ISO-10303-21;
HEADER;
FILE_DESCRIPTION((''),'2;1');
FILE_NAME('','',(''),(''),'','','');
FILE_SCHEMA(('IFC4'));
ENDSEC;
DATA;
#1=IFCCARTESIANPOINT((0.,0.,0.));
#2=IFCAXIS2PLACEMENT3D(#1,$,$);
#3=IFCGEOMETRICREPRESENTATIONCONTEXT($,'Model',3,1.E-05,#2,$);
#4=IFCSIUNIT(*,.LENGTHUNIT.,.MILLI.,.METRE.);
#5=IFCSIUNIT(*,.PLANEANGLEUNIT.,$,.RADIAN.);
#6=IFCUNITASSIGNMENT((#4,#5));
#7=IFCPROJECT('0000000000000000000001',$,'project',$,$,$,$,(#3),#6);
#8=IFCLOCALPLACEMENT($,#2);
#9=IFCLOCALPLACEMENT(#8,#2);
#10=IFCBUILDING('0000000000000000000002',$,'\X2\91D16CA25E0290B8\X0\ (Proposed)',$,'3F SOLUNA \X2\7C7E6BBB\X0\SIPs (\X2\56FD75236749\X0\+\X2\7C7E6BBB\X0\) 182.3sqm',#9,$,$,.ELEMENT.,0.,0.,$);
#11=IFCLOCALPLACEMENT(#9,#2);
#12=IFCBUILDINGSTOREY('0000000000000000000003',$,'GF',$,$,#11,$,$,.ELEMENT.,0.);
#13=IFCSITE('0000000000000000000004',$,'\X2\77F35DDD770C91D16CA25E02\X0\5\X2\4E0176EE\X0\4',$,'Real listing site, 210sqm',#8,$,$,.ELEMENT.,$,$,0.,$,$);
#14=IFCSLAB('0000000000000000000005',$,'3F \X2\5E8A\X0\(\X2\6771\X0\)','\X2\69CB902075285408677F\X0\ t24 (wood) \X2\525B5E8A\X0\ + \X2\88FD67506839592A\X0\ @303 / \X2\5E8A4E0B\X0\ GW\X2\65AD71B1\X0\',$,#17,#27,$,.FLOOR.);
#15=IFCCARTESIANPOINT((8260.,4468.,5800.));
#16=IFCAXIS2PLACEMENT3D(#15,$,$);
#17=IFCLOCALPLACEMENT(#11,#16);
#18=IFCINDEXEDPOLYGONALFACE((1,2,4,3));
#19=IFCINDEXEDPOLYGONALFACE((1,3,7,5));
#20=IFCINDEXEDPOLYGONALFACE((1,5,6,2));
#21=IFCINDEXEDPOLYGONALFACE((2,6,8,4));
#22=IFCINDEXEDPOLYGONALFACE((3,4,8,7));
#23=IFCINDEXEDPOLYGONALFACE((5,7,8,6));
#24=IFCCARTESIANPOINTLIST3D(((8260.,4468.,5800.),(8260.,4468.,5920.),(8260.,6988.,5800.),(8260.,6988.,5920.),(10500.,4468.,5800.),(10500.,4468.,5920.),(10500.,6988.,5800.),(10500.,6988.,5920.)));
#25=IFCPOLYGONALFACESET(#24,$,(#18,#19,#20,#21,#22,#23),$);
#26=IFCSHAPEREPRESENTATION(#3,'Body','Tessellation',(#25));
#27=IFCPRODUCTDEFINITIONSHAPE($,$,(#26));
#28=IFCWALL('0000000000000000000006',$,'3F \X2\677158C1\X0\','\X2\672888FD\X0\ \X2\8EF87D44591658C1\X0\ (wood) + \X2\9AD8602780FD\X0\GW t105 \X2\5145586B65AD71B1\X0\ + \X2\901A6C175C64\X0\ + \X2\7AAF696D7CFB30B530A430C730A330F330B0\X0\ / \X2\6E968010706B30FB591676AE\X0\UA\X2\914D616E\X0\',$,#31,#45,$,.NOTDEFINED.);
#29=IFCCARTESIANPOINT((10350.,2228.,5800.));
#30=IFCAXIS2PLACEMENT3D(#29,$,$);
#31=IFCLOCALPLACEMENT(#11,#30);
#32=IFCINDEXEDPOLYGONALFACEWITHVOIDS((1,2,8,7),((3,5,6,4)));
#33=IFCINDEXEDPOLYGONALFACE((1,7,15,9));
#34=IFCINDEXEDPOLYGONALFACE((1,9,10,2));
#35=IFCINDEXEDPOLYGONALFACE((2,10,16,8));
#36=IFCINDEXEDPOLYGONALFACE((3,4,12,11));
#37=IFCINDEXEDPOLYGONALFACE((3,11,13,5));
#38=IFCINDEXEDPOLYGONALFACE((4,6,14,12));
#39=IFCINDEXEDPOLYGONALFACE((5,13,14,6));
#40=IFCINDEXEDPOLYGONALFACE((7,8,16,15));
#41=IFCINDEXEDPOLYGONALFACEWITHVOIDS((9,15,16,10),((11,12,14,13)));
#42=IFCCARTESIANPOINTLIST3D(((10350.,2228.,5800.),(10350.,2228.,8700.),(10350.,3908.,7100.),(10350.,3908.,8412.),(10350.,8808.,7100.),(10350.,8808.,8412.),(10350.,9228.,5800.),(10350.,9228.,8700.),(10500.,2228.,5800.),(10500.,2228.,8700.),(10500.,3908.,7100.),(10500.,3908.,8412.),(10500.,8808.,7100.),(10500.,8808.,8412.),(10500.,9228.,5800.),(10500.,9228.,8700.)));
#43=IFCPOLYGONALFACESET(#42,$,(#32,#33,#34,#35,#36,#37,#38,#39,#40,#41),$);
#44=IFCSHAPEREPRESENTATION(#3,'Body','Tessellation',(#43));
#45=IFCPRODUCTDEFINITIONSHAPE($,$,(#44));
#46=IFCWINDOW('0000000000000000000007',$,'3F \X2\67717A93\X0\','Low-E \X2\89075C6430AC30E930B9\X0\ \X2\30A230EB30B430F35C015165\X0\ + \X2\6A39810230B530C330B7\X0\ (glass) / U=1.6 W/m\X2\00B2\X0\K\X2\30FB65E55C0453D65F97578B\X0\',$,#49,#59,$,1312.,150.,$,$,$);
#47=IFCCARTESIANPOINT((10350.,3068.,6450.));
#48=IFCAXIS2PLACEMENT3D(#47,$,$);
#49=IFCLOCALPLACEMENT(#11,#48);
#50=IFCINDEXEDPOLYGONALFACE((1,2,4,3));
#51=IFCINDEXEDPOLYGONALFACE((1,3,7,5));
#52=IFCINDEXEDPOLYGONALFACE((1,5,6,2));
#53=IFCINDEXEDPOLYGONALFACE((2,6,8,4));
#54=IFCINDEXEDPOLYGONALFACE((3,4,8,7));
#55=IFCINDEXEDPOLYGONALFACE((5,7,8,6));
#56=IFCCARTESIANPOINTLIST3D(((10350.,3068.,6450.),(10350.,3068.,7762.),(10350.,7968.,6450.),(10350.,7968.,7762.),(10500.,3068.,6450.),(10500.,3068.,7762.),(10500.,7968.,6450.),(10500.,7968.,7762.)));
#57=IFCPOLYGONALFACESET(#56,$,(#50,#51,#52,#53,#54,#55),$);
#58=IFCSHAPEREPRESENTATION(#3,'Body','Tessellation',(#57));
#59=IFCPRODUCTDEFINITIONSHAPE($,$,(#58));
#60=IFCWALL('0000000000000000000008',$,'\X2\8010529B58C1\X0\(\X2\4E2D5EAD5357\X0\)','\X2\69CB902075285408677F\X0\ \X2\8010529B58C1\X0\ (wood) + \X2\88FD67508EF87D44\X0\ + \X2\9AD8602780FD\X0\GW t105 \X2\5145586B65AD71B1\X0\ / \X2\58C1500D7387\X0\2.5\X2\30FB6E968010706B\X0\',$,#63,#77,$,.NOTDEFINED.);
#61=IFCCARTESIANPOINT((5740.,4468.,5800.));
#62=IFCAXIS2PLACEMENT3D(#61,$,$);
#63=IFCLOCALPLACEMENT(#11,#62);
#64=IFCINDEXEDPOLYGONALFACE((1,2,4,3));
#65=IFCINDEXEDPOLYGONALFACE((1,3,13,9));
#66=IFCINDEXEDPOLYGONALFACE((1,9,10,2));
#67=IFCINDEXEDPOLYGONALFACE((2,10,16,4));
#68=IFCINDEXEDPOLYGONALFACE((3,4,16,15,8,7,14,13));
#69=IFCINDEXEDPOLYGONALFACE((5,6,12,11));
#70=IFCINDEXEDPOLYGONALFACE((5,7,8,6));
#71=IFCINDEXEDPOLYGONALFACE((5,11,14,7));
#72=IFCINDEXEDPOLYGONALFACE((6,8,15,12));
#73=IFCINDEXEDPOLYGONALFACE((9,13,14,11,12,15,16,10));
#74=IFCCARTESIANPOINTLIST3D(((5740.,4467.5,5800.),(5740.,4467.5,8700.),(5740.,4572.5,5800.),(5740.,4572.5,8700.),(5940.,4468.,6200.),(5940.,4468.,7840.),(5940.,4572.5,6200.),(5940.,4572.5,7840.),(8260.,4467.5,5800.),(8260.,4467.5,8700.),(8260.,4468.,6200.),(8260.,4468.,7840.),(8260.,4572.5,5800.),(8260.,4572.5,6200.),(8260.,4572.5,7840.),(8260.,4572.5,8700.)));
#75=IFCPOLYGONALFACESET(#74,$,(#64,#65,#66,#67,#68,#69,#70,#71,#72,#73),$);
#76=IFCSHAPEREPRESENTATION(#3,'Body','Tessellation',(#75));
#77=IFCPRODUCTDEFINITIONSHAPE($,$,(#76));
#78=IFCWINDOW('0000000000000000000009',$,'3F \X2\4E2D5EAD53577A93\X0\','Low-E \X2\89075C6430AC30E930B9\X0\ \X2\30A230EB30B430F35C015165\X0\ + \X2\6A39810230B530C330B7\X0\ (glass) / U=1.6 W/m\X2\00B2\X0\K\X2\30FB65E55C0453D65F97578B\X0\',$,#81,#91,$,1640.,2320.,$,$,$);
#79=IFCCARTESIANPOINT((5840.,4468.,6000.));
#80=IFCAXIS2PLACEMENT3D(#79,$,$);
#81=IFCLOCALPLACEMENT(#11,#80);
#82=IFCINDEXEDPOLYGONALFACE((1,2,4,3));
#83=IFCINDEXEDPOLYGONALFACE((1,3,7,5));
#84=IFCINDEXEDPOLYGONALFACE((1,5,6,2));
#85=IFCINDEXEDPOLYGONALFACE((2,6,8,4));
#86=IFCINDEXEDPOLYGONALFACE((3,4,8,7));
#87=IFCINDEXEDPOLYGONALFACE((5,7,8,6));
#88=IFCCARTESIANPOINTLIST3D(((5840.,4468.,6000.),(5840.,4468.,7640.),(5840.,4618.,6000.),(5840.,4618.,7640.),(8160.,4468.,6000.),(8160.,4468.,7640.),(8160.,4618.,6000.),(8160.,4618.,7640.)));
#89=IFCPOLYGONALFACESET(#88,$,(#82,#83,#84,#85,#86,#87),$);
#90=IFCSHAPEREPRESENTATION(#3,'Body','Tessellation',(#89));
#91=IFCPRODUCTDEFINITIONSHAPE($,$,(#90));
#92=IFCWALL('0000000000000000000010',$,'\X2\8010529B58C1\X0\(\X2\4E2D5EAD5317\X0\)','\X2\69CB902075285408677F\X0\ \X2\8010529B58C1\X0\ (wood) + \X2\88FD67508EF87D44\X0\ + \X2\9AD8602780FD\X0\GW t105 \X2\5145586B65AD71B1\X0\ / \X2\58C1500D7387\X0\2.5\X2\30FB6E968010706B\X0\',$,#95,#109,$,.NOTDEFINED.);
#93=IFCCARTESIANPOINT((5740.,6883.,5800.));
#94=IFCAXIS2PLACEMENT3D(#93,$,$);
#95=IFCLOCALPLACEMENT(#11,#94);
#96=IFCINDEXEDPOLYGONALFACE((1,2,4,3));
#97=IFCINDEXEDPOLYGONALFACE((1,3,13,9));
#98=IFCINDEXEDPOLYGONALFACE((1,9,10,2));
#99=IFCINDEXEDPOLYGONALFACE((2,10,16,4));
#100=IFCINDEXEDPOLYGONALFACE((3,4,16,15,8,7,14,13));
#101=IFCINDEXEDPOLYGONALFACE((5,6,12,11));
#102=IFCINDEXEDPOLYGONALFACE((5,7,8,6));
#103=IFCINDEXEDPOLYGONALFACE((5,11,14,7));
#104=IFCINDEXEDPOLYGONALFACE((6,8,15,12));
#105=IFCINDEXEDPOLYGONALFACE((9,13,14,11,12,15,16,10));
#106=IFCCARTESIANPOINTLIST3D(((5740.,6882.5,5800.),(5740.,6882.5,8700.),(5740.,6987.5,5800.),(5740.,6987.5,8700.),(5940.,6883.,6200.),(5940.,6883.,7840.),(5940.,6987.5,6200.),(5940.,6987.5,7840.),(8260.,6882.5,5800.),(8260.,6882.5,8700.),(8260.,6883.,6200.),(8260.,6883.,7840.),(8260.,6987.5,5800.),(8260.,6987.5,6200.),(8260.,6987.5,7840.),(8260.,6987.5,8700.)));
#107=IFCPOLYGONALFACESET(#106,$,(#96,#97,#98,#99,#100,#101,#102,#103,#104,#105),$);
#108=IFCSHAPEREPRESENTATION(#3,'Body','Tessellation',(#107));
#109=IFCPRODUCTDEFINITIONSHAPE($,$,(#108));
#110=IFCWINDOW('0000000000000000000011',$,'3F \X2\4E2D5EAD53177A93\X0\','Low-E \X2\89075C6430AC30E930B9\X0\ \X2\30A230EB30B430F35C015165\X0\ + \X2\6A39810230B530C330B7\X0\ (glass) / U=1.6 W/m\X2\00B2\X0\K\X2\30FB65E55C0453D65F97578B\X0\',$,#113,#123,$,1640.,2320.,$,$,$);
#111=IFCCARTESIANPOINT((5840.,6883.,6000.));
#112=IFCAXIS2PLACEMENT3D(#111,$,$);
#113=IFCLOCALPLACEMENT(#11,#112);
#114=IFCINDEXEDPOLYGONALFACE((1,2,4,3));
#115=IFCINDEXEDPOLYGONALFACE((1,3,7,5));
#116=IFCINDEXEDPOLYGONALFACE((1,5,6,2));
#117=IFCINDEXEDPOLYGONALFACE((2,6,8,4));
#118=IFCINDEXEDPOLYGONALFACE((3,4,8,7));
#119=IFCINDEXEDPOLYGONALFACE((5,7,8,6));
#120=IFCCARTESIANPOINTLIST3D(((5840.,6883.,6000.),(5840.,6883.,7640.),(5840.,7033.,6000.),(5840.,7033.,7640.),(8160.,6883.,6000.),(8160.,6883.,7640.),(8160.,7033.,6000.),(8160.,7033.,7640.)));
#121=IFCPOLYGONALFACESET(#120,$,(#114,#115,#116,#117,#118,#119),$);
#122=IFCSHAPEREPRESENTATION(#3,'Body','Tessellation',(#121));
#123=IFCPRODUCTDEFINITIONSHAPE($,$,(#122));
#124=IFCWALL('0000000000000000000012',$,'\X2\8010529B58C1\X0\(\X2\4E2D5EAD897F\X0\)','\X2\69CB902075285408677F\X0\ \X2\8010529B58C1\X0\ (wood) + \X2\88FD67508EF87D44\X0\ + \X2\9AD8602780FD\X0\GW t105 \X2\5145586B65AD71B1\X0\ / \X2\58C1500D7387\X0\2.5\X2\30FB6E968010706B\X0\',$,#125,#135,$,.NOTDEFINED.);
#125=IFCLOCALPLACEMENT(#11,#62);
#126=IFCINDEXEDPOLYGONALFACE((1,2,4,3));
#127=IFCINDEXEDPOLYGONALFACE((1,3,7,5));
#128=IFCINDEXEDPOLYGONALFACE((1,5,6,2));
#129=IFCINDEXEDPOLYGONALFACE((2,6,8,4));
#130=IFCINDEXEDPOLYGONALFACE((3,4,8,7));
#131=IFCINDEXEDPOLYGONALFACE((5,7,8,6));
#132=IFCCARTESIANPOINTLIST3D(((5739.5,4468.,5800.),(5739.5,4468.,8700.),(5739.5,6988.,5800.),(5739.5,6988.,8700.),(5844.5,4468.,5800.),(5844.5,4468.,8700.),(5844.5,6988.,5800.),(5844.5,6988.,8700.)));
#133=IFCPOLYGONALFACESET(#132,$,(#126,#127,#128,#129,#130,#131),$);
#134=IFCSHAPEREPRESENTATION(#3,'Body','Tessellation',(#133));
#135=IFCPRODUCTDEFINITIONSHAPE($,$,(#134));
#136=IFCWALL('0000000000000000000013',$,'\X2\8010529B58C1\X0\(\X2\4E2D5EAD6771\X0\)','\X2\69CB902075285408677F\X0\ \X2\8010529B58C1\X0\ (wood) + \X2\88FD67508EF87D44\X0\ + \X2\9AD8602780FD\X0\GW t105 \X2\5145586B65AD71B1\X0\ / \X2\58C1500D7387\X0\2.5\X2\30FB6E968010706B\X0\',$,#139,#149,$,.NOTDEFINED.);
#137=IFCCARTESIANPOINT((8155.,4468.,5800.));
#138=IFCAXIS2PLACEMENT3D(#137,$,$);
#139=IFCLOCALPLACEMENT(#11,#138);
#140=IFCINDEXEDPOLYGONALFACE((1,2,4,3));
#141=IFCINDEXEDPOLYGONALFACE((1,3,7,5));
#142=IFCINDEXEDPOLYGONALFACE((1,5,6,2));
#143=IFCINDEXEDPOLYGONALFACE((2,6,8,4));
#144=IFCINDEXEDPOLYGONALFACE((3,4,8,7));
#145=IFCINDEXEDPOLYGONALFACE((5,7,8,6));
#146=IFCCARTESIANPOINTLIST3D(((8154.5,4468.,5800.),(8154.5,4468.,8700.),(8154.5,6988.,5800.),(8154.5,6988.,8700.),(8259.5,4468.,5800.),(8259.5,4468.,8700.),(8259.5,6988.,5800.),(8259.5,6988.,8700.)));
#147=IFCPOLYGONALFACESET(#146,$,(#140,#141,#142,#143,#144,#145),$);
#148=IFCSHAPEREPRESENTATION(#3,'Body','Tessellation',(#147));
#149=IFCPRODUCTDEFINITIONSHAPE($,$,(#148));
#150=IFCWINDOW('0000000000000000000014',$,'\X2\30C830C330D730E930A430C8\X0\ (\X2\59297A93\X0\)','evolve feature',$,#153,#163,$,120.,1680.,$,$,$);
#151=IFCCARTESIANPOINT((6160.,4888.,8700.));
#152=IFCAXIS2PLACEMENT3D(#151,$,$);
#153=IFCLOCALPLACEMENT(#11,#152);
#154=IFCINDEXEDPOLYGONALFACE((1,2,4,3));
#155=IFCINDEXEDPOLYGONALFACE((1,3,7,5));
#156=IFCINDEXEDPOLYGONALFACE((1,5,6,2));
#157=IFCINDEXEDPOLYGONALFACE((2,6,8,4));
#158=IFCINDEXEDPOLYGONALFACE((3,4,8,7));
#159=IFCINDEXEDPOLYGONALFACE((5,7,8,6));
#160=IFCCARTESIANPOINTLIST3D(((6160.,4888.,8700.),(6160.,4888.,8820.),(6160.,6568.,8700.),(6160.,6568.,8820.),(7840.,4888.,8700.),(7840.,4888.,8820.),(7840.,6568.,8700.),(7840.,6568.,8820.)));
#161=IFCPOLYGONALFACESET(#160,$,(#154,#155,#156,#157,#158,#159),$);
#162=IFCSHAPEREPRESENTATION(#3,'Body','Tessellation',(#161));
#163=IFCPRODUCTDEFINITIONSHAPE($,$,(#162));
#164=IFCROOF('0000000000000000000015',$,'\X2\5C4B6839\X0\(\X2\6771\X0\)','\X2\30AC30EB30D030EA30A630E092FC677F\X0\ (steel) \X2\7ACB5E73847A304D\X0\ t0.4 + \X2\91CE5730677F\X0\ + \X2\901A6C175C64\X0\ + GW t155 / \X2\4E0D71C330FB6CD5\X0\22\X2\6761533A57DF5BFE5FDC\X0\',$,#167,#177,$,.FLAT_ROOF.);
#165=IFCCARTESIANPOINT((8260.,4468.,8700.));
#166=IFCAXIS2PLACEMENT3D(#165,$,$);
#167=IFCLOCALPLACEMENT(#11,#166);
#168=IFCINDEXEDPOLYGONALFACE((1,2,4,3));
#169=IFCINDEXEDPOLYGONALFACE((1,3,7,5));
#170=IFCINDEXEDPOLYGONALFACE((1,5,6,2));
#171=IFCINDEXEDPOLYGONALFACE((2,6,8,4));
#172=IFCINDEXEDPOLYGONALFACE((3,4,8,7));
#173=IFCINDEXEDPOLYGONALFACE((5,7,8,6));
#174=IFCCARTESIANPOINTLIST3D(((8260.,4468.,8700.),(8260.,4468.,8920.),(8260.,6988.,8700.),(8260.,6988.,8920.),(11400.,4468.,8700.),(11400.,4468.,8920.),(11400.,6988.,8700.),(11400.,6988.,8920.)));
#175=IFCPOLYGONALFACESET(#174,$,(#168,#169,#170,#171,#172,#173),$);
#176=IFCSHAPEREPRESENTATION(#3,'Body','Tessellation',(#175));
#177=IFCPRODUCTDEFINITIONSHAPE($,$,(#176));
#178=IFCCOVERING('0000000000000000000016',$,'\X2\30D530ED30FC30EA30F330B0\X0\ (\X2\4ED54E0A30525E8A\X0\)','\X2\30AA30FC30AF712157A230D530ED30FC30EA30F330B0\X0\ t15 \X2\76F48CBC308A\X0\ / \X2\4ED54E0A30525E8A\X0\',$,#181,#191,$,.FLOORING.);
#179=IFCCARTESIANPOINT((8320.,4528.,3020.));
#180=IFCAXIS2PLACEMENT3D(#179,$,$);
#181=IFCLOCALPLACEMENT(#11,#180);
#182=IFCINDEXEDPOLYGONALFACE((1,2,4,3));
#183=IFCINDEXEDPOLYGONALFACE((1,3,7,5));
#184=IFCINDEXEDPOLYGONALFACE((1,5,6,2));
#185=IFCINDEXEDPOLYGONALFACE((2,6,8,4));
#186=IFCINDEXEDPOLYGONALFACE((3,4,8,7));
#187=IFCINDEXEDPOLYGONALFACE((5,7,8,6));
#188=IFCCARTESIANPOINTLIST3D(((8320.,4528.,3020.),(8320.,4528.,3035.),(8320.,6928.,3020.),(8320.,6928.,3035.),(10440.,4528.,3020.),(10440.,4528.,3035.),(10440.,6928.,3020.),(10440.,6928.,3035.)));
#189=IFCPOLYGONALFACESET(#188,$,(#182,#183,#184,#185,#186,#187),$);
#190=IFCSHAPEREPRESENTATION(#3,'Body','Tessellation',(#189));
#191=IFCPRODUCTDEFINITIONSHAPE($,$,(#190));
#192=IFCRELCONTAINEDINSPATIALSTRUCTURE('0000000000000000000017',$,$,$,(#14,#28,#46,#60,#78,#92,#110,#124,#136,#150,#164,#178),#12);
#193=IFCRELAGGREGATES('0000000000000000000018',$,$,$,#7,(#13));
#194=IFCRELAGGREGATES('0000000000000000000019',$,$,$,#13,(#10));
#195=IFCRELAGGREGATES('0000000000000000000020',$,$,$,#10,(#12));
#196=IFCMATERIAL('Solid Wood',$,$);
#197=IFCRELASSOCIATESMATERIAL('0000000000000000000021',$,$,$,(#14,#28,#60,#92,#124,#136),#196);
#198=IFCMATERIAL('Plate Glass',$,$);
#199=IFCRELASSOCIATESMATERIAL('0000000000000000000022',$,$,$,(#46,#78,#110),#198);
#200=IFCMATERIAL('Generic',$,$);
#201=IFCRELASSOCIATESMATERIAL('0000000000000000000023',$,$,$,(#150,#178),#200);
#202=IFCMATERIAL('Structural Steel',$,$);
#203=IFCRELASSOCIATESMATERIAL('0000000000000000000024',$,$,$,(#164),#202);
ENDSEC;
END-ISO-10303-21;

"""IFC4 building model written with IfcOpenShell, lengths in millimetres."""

from ifc_helpers import new_model, si_unit, frame, frame_2d, origin, place, context, project, spatial, rectangle, extrude, material, element, fill, save


model = new_model("IFC4")

# Units and contexts
model_context = context("Model", 3, precision=1e-05, world=origin())
ifc_project = project(units=[si_unit("LENGTHUNIT", "METRE", prefix="MILLI"), si_unit("PLANEANGLEUNIT", "RADIAN")], contexts=[model_context])

# Site, building, storey
site_placement = place(None, origin())
site = spatial("IfcSite", under=ifc_project, at=site_placement, Name="石川県金沢市5丁目4", ObjectType="Real listing site, 210sqm", CompositionType="ELEMENT", RefElevation=0.0)
building_placement = place(site_placement, origin())
building = spatial("IfcBuilding", under=site, at=building_placement, Name="金沢市邸 (Proposed)", ObjectType="3F SOLUNA 籾殻SIPs (国産杉+籾殻) 182.3sqm", CompositionType="ELEMENT", ElevationOfRefHeight=0.0, ElevationOfTerrain=0.0)
storey_placement = place(building_placement, origin())
storey = spatial("IfcBuildingStorey", under=building, at=storey_placement, Name="GF", CompositionType="ELEMENT", Elevation=0.0)

# Slab
ifc_material_1 = material(Name="Solid Wood")
slab_placement = place(storey_placement, frame((8260.0, 4468.0, 5800.0)))
element("IfcSlab", 1, at=slab_placement, inside=storey, material=ifc_material_1, Name="3F 床(東)", Description="構造用合板 t24 (wood) 剛床 + 製材根太 @303 / 床下 GW断熱", PredefinedType="FLOOR", context=model_context, shape_type="SweptSolid", body=[
    extrude(rectangle(XDim=2240.0, YDim=2520.0, at=frame_2d((1120.0, 1260.0))), frame((8260.0, 4468.0, 5800.0)), (0.0, 0.0, 1.0), 120.0),
])

# Walls, openings, windows
wall_1_placement = place(storey_placement, frame((10350.0, 2228.0, 5800.0)))
wall_1 = element("IfcWall", 2, at=wall_1_placement, inside=storey, material=ifc_material_1, Name="3F 東壁", Description="木製 軸組外壁 (wood) + 高性能GW t105 充填断熱 + 通気層 + 窯業系サイディング / 準耐火・外皮UA配慮", PredefinedType="NOTDEFINED", context=model_context, shape_type="SweptSolid", body=[
    extrude(rectangle(XDim=150.0, YDim=7000.0, at=frame_2d((75.0, 3500.0))), frame((10350.0, 2228.0, 5800.0)), (0.0, 0.0, 1.0), 2900.0),
])
opening_1_placement = place(storey_placement, frame((10350.0, 3068.0, 6450.0)))
opening_1 = element("IfcOpeningElement", 3, at=opening_1_placement, cuts=wall_1, PredefinedType="NOTDEFINED", context=model_context, shape_type="SweptSolid", body=[
    extrude(rectangle(XDim=150.0, YDim=4900.0, at=frame_2d((75.0, 2450.0))), frame((10350.0, 3068.0, 6450.0)), (0.0, 0.0, 1.0), 1312.0),
])
ifc_material_2 = material(Name="Plate Glass")
window_1_placement = place(storey_placement, frame((10350.0, 3068.0, 6450.0)))
window_1 = element("IfcWindow", 4, at=window_1_placement, inside=storey, material=ifc_material_2, Name="3F 東窓", Description="Low-E 複層ガラス アルゴン封入 + 樹脂サッシ (glass) / U=1.6 W/m²K・日射取得型", OverallHeight=1312.0, OverallWidth=150.0, context=model_context, shape_type="SweptSolid", body=[
    extrude(rectangle(XDim=150.0, YDim=4900.0, at=frame_2d((75.0, 2450.0))), frame((10350.0, 3068.0, 6450.0)), (0.0, 0.0, 1.0), 1312.0),
])
fill(opening_1, window_1)
wall_2_placement = place(storey_placement, frame((5740.0, 4468.0, 5800.0)))
wall_2 = element("IfcWall", 5, at=wall_2_placement, inside=storey, material=ifc_material_1, Name="耐力壁(中庭南)", Description="構造用合板 耐力壁 (wood) + 製材軸組 + 高性能GW t105 充填断熱 / 壁倍率2.5・準耐火", PredefinedType="NOTDEFINED", context=model_context, shape_type="SweptSolid", body=[
    extrude(rectangle(XDim=2520.0, YDim=105.0, at=frame_2d((1260.0, 52.0))), frame((5740.0, 4468.0, 5800.0)), (0.0, 0.0, 1.0), 2900.0),
])
opening_2_placement = place(storey_placement, frame((5840.0, 4468.0, 6000.0)))
opening_2 = element("IfcOpeningElement", 6, at=opening_2_placement, cuts=wall_2, PredefinedType="NOTDEFINED", context=model_context, shape_type="SweptSolid", body=[
    extrude(rectangle(XDim=2320.0, YDim=150.0, at=frame_2d((1160.0, 75.0))), frame((5840.0, 4468.0, 6000.0)), (0.0, 0.0, 1.0), 1640.0),
])
window_2_placement = place(storey_placement, frame((5840.0, 4468.0, 6000.0)))
window_2 = element("IfcWindow", 7, at=window_2_placement, inside=storey, material=ifc_material_2, Name="3F 中庭南窓", Description="Low-E 複層ガラス アルゴン封入 + 樹脂サッシ (glass) / U=1.6 W/m²K・日射取得型", OverallHeight=1640.0, OverallWidth=2320.0, context=model_context, shape_type="SweptSolid", body=[
    extrude(rectangle(XDim=2320.0, YDim=150.0, at=frame_2d((1160.0, 75.0))), frame((5840.0, 4468.0, 6000.0)), (0.0, 0.0, 1.0), 1640.0),
])
fill(opening_2, window_2)
wall_3_placement = place(storey_placement, frame((5740.0, 6883.0, 5800.0)))
wall_3 = element("IfcWall", 8, at=wall_3_placement, inside=storey, material=ifc_material_1, Name="耐力壁(中庭北)", Description="構造用合板 耐力壁 (wood) + 製材軸組 + 高性能GW t105 充填断熱 / 壁倍率2.5・準耐火", PredefinedType="NOTDEFINED", context=model_context, shape_type="SweptSolid", body=[
    extrude(rectangle(XDim=2520.0, YDim=105.0, at=frame_2d((1260.0, 52.0))), frame((5740.0, 6883.0, 5800.0)), (0.0, 0.0, 1.0), 2900.0),
])
opening_3_placement = place(storey_placement, frame((5840.0, 6883.0, 6000.0)))
opening_3 = element("IfcOpeningElement", 9, at=opening_3_placement, cuts=wall_3, PredefinedType="NOTDEFINED", context=model_context, shape_type="SweptSolid", body=[
    extrude(rectangle(XDim=2320.0, YDim=150.0, at=frame_2d((1160.0, 75.0))), frame((5840.0, 6883.0, 6000.0)), (0.0, 0.0, 1.0), 1640.0),
])
window_3_placement = place(storey_placement, frame((5840.0, 6883.0, 6000.0)))
window_3 = element("IfcWindow", 10, at=window_3_placement, inside=storey, material=ifc_material_2, Name="3F 中庭北窓", Description="Low-E 複層ガラス アルゴン封入 + 樹脂サッシ (glass) / U=1.6 W/m²K・日射取得型", OverallHeight=1640.0, OverallWidth=2320.0, context=model_context, shape_type="SweptSolid", body=[
    extrude(rectangle(XDim=2320.0, YDim=150.0, at=frame_2d((1160.0, 75.0))), frame((5840.0, 6883.0, 6000.0)), (0.0, 0.0, 1.0), 1640.0),
])
fill(opening_3, window_3)

# Walls
wall_4_placement = place(storey_placement, frame((5740.0, 4468.0, 5800.0)))
element("IfcWall", 11, at=wall_4_placement, inside=storey, material=ifc_material_1, Name="耐力壁(中庭西)", Description="構造用合板 耐力壁 (wood) + 製材軸組 + 高性能GW t105 充填断熱 / 壁倍率2.5・準耐火", PredefinedType="NOTDEFINED", context=model_context, shape_type="SweptSolid", body=[
    extrude(rectangle(XDim=105.0, YDim=2520.0, at=frame_2d((52.0, 1260.0))), frame((5740.0, 4468.0, 5800.0)), (0.0, 0.0, 1.0), 2900.0),
])
wall_5_placement = place(storey_placement, frame((8155.0, 4468.0, 5800.0)))
element("IfcWall", 12, at=wall_5_placement, inside=storey, material=ifc_material_1, Name="耐力壁(中庭東)", Description="構造用合板 耐力壁 (wood) + 製材軸組 + 高性能GW t105 充填断熱 / 壁倍率2.5・準耐火", PredefinedType="NOTDEFINED", context=model_context, shape_type="SweptSolid", body=[
    extrude(rectangle(XDim=105.0, YDim=2520.0, at=frame_2d((52.0, 1260.0))), frame((8155.0, 4468.0, 5800.0)), (0.0, 0.0, 1.0), 2900.0),
])

# Window
ifc_material_3 = material(Name="Generic")
window_4_placement = place(storey_placement, frame((6160.0, 4888.0, 8700.0)))
element("IfcWindow", 13, at=window_4_placement, inside=storey, material=ifc_material_3, Name="トップライト (天窓)", Description="evolve feature", OverallHeight=120.0, OverallWidth=1680.0, context=model_context, shape_type="SweptSolid", body=[
    extrude(rectangle(XDim=1680.0, YDim=1680.0, at=frame_2d((840.0, 840.0))), frame((6160.0, 4888.0, 8700.0)), (0.0, 0.0, 1.0), 120.0),
])

# Roof
ifc_material_4 = material(Name="Structural Steel")
for number, where, name in (
    (14, (8260.0, 4468.0, 8700.0), "屋根(東)"),
):
    element("IfcRoof", number, at=place(storey_placement, frame(where)), inside=storey, material=ifc_material_4, Name=name, Description="ガルバリウム鋼板 (steel) 立平葺き t0.4 + 野地板 + 通気層 + GW t155 / 不燃・法22条区域対応", PredefinedType="FLAT_ROOF", context=model_context, shape_type="SweptSolid", body=[
        extrude(rectangle(XDim=3140.0, YDim=2520.0, at=frame_2d((1570.0, 1260.0))), frame((8260.0, 4468.0, 8700.0)), (0.0, 0.0, 1.0), 220.0),
    ])

# Covering
covering_1_placement = place(storey_placement, frame((8320.0, 4528.0, 3020.0)))
element("IfcCovering", 15, at=covering_1_placement, inside=storey, material=ifc_material_3, Name="フローリング (仕上げ床)", Description="オーク無垢フローリング t15 直貼り / 仕上げ床", PredefinedType="FLOORING", context=model_context, shape_type="SweptSolid", body=[
    extrude(rectangle(XDim=2120.0, YDim=2400.0, at=frame_2d((1060.0, 1200.0))), frame((8320.0, 4528.0, 3020.0)), (0.0, 0.0, 1.0), 15.0),
])

save(model, "model.ifc")
